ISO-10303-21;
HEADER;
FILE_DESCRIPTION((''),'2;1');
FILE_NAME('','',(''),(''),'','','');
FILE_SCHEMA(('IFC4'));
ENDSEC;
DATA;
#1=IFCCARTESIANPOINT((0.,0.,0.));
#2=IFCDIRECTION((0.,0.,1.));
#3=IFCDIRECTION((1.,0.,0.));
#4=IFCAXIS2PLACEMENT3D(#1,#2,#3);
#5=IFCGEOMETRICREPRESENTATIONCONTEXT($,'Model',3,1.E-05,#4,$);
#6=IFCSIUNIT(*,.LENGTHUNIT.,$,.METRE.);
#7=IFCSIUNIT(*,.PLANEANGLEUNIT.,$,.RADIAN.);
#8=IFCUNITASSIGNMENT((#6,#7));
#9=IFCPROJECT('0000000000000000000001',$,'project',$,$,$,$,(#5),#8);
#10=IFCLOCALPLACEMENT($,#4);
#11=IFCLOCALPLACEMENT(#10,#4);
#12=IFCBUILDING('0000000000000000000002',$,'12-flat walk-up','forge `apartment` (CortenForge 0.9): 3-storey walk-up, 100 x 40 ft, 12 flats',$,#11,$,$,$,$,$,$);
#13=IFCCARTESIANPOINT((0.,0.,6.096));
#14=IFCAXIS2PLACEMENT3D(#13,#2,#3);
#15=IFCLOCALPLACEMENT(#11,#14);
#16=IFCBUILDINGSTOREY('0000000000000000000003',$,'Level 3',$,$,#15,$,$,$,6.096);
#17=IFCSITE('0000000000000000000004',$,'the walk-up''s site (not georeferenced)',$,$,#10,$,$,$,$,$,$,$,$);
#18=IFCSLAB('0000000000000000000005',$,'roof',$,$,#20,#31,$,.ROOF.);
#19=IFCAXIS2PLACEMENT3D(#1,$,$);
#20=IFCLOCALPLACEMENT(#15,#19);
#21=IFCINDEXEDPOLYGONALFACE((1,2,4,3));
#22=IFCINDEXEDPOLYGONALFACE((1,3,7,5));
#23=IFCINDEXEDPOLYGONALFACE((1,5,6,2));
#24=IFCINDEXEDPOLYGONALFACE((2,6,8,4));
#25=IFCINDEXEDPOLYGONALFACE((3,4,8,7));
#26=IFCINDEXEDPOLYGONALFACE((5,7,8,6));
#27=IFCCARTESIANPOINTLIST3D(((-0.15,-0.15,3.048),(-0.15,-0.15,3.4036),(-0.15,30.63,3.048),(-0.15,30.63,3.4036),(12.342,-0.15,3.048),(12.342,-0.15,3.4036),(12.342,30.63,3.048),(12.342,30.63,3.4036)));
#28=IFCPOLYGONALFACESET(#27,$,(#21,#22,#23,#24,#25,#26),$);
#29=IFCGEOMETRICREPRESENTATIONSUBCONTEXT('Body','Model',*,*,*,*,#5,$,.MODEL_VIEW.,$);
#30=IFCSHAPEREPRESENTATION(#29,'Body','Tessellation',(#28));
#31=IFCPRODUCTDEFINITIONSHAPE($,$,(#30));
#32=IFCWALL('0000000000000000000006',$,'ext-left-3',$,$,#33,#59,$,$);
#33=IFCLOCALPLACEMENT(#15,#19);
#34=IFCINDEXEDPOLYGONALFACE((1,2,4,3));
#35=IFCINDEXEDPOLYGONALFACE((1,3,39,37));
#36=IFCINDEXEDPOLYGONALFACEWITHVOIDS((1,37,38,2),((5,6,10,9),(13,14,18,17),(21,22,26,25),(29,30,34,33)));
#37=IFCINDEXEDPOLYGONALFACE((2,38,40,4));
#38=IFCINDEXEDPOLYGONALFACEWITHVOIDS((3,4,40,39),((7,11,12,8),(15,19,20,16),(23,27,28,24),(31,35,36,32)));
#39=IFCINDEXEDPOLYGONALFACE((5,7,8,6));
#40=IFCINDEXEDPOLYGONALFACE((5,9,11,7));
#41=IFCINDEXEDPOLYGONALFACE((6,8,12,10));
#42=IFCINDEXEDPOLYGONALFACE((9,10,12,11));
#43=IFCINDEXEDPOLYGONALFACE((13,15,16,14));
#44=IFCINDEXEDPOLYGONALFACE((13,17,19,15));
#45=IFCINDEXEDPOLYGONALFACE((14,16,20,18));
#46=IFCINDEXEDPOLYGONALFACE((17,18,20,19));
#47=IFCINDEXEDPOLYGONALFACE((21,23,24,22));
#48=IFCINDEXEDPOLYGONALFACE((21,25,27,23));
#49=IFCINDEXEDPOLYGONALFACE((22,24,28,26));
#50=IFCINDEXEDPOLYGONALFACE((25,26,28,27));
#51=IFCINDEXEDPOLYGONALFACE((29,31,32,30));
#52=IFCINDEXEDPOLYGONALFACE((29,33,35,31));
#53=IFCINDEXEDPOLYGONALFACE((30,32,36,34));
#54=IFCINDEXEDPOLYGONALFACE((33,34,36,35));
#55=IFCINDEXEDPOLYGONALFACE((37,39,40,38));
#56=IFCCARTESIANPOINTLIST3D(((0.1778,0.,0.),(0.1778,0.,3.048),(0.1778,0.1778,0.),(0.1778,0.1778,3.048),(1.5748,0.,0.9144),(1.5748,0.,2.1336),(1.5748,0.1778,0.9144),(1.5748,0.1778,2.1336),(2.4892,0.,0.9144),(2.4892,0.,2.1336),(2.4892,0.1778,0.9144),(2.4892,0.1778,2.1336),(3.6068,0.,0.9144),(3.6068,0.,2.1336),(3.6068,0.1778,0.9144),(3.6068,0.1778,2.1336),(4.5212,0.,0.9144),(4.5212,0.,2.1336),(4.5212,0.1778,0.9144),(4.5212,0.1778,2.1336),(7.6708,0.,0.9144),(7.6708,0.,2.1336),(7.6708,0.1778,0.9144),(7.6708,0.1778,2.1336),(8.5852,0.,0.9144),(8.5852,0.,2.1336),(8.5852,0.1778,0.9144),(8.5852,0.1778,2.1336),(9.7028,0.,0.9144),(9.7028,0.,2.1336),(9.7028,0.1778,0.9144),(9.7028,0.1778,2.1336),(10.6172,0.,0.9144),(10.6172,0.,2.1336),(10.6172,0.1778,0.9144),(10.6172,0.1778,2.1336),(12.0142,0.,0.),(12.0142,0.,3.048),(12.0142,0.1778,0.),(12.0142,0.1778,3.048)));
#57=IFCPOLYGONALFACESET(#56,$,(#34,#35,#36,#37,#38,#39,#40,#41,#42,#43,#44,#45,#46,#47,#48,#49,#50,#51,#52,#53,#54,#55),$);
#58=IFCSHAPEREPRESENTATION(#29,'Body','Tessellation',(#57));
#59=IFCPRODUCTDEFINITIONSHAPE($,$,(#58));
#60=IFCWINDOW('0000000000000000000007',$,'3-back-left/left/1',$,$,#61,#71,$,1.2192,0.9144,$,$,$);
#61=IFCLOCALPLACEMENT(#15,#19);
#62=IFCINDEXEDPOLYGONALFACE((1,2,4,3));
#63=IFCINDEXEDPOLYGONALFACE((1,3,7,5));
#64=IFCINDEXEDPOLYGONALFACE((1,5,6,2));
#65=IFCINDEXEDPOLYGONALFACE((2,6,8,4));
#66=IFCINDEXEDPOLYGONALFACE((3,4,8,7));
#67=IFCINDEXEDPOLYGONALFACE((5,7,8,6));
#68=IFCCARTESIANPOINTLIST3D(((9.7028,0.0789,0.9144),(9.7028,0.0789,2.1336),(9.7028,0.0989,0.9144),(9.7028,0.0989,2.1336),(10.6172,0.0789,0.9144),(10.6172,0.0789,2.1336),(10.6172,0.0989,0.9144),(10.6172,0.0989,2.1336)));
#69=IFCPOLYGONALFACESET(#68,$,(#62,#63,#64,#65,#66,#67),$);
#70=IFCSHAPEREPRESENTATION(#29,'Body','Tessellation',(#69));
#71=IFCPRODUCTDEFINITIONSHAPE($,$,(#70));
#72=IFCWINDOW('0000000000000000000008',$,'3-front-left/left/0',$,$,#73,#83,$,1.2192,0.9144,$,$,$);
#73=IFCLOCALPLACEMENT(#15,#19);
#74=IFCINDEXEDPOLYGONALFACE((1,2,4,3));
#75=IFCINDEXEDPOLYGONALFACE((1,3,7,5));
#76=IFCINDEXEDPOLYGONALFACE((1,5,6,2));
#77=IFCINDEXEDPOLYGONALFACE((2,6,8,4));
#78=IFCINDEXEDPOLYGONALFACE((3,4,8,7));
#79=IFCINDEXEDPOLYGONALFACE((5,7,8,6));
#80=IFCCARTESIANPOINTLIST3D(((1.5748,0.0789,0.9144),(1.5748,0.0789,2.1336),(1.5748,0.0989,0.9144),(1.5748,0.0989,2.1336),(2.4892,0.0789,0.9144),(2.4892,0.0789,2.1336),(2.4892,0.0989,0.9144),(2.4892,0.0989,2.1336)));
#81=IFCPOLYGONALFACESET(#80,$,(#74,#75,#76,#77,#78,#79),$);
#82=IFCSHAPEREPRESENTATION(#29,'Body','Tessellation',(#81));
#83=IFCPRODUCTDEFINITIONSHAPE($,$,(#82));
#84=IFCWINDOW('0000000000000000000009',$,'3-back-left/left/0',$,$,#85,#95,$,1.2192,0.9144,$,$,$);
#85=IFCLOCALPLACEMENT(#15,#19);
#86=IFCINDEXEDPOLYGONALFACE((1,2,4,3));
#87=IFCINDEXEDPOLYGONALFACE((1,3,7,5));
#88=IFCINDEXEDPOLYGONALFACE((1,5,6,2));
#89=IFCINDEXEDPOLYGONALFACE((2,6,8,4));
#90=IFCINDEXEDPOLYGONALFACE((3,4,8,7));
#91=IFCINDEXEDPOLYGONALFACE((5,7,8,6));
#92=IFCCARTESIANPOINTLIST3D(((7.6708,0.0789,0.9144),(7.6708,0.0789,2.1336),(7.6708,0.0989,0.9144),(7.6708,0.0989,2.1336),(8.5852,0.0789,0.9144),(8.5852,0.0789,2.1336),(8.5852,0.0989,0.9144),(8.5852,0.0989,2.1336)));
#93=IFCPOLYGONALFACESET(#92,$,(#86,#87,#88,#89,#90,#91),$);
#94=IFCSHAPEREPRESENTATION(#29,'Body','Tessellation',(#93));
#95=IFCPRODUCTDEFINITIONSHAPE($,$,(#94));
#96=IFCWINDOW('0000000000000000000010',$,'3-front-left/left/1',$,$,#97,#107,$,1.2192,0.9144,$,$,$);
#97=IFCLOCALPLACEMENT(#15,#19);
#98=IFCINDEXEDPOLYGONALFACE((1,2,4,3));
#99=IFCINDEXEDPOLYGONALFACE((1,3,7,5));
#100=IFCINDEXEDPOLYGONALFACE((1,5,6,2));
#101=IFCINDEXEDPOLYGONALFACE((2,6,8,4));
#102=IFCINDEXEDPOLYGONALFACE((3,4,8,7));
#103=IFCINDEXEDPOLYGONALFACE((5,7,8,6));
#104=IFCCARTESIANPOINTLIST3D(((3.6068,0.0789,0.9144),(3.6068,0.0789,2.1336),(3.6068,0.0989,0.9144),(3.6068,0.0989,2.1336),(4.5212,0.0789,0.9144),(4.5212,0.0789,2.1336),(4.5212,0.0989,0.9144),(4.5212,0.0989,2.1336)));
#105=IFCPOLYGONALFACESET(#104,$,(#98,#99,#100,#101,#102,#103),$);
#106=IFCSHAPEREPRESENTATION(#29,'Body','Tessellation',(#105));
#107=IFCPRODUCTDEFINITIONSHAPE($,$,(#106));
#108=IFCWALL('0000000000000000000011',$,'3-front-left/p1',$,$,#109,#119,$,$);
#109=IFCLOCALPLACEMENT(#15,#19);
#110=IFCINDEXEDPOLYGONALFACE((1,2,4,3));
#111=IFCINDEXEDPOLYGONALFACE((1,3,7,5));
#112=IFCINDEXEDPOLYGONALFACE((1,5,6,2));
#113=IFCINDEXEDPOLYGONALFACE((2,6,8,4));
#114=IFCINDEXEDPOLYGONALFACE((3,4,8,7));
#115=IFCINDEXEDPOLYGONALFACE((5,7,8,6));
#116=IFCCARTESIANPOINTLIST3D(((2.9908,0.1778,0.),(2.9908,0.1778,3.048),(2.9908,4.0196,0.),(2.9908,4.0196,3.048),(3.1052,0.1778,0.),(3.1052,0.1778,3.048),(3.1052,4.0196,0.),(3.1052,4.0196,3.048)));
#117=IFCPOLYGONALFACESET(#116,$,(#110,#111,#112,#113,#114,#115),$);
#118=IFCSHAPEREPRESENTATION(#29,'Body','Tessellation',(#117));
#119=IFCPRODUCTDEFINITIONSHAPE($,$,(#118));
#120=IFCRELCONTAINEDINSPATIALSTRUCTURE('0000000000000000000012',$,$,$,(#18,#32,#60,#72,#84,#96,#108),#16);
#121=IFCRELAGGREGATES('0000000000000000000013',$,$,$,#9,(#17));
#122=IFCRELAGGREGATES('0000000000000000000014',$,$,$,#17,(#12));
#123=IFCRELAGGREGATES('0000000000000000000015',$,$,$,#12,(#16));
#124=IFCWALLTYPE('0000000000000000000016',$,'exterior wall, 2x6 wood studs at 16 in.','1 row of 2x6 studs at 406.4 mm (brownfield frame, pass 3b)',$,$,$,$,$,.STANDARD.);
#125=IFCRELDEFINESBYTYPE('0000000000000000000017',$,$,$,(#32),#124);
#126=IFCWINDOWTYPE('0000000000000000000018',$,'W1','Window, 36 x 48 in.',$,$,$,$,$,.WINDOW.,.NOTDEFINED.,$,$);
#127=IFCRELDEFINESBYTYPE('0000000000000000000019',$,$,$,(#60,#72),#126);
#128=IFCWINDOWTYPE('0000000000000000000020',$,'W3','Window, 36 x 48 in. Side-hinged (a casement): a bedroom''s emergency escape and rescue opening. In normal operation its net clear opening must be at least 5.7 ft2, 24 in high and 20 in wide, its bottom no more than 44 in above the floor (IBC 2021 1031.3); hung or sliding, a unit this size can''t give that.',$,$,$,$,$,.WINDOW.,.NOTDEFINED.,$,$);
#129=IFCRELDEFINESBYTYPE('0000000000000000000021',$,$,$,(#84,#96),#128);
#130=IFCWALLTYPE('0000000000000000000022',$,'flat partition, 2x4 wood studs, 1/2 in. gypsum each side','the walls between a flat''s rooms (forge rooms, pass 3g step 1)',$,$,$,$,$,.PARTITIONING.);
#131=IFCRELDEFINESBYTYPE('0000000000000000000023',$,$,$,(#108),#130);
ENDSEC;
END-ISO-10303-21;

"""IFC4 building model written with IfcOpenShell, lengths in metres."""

from ifc_helpers import new_model, si_unit, frame, frame_2d, origin, origin_with_axes, place, context, subcontext, project, spatial, rectangle, extrude, type_object, element, fill, save


model = new_model("IFC4")

# Units and contexts
model_context = context("Model", 3, precision=1e-05, world=origin_with_axes())
body_context = subcontext(model_context, "Body", "Model", "MODEL_VIEW")
ifc_project = project(units=[si_unit("LENGTHUNIT", "METRE"), si_unit("PLANEANGLEUNIT", "RADIAN")], contexts=[model_context])

# Site, building, storey
site_placement = place(None, origin_with_axes())
site = spatial("IfcSite", under=ifc_project, at=site_placement, Name="the walk-up's site (not georeferenced)")
building_placement = place(site_placement, origin_with_axes())
building = spatial("IfcBuilding", under=site, at=building_placement, Name="12-flat walk-up", Description="forge `apartment` (CortenForge 0.9): 3-storey walk-up, 100 x 40 ft, 12 flats")
storey_placement = place(building_placement, frame((0.0, 0.0, 6.096), z_axis=(0.0, 0.0, 1.0), x_axis=(1.0, 0.0, 0.0)))
storey = spatial("IfcBuildingStorey", under=building, at=storey_placement, Name="Level 3", Elevation=6.096)

# Slab
slab_placement = place(storey_placement, frame((-0.15, -0.15, 3.048), z_axis=(0.0, 0.0, 1.0), x_axis=(1.0, 0.0, 0.0)))
element("IfcSlab", 1, at=slab_placement, inside=storey, Name="roof", PredefinedType="ROOF", context=body_context, shape_type="SweptSolid", body=[
    extrude(rectangle(XDim=12.492, YDim=30.78, at=frame_2d((6.246, 15.39))), origin(), (0.0, 0.0, 1.0), 0.3556),
])

# Wall, openings, windows
wall_type_1 = type_object("IfcWallType", Name="exterior wall, 2x6 wood studs at 16 in.", Description="1 row of 2x6 studs at 406.4 mm (brownfield frame, pass 3b)", PredefinedType="STANDARD")
wall_1_placement = place(storey_placement, frame((0.1778, 0.0, 0.0), z_axis=(0.0, 0.0, 1.0), x_axis=(1.0, 0.0, 0.0)))
wall_1 = element("IfcWall", 2, at=wall_1_placement, inside=storey, type_object=wall_type_1, Name="ext-left-3", context=body_context, shape_type="SweptSolid", body=[
    extrude(rectangle(XDim=11.8364, YDim=0.1778, at=frame_2d((5.9182, 0.0889))), origin(), (0.0, 0.0, 1.0), 3.048),
])
opening_1_placement = place(wall_1_placement, frame((7.493, 0.0, 0.9144), z_axis=(0.0, 0.0, 1.0), x_axis=(1.0, 0.0, 0.0)))
opening_1 = element("IfcOpeningElement", 3, at=opening_1_placement, cuts=wall_1, PredefinedType="OPENING", context=body_context, shape_type="SweptSolid", body=[
    extrude(rectangle(XDim=0.9144, YDim=0.1778, at=frame_2d((0.4572, 0.0889))), origin(), (0.0, 0.0, 1.0), 1.2192),
])
opening_2_placement = place(wall_1_placement, frame((9.525, 0.0, 0.9144), z_axis=(0.0, 0.0, 1.0), x_axis=(1.0, 0.0, 0.0)))
opening_2 = element("IfcOpeningElement", 4, at=opening_2_placement, cuts=wall_1, PredefinedType="OPENING", context=body_context, shape_type="SweptSolid", body=[
    extrude(rectangle(XDim=0.9144, YDim=0.1778, at=frame_2d((0.4572, 0.0889))), origin(), (0.0, 0.0, 1.0), 1.2192),
])
opening_3_placement = place(wall_1_placement, frame((1.397, 0.0, 0.9144), z_axis=(0.0, 0.0, 1.0), x_axis=(1.0, 0.0, 0.0)))
opening_3 = element("IfcOpeningElement", 5, at=opening_3_placement, cuts=wall_1, PredefinedType="OPENING", context=body_context, shape_type="SweptSolid", body=[
    extrude(rectangle(XDim=0.9144, YDim=0.1778, at=frame_2d((0.4572, 0.0889))), origin(), (0.0, 0.0, 1.0), 1.2192),
])
opening_4_placement = place(wall_1_placement, frame((3.429, 0.0, 0.9144), z_axis=(0.0, 0.0, 1.0), x_axis=(1.0, 0.0, 0.0)))
opening_4 = element("IfcOpeningElement", 6, at=opening_4_placement, cuts=wall_1, PredefinedType="OPENING", context=body_context, shape_type="SweptSolid", body=[
    extrude(rectangle(XDim=0.9144, YDim=0.1778, at=frame_2d((0.4572, 0.0889))), origin(), (0.0, 0.0, 1.0), 1.2192),
])
window_type_1 = type_object("IfcWindowType", Name="W1", Description="Window, 36 x 48 in.", PartitioningType="NOTDEFINED", PredefinedType="WINDOW")
window_1_placement = place(opening_2_placement, frame((0.0, 0.0789, 0.0), z_axis=(0.0, 0.0, 1.0), x_axis=(1.0, 0.0, 0.0)))
window_1 = element("IfcWindow", 7, at=window_1_placement, inside=storey, type_object=window_type_1, Name="3-back-left/left/1", OverallHeight=1.2192, OverallWidth=0.9144, context=body_context, shape_type="SweptSolid", body=[
    extrude(rectangle(XDim=0.9144, YDim=0.02, at=frame_2d((0.4572, 0.01))), origin(), (0.0, 0.0, 1.0), 1.2192),
])
fill(opening_2, window_1)
window_2_placement = place(opening_3_placement, frame((0.0, 0.0789, 0.0), z_axis=(0.0, 0.0, 1.0), x_axis=(1.0, 0.0, 0.0)))
window_2 = element("IfcWindow", 8, at=window_2_placement, inside=storey, type_object=window_type_1, Name="3-front-left/left/0", OverallHeight=1.2192, OverallWidth=0.9144, context=body_context, shape_type="SweptSolid", body=[
    extrude(rectangle(XDim=0.9144, YDim=0.02, at=frame_2d((0.4572, 0.01))), origin(), (0.0, 0.0, 1.0), 1.2192),
])
fill(opening_3, window_2)
window_type_2 = type_object("IfcWindowType", Name="W3", Description="Window, 36 x 48 in. Side-hinged (a casement): a bedroom's emergency escape and rescue opening. In normal operation its net clear opening must be at least 5.7 ft2, 24 in high and 20 in wide, its bottom no more than 44 in above the floor (IBC 2021 1031.3); hung or sliding, a unit this size can't give that.", PartitioningType="NOTDEFINED", PredefinedType="WINDOW")
window_3_placement = place(opening_1_placement, frame((0.0, 0.0789, 0.0), z_axis=(0.0, 0.0, 1.0), x_axis=(1.0, 0.0, 0.0)))
window_3 = element("IfcWindow", 9, at=window_3_placement, inside=storey, type_object=window_type_2, Name="3-back-left/left/0", OverallHeight=1.2192, OverallWidth=0.9144, context=body_context, shape_type="SweptSolid", body=[
    extrude(rectangle(XDim=0.9144, YDim=0.02, at=frame_2d((0.4572, 0.01))), origin(), (0.0, 0.0, 1.0), 1.2192),
])
fill(opening_1, window_3)
window_4_placement = place(opening_4_placement, frame((0.0, 0.0789, 0.0), z_axis=(0.0, 0.0, 1.0), x_axis=(1.0, 0.0, 0.0)))
window_4 = element("IfcWindow", 10, at=window_4_placement, inside=storey, type_object=window_type_2, Name="3-front-left/left/1", OverallHeight=1.2192, OverallWidth=0.9144, context=body_context, shape_type="SweptSolid", body=[
    extrude(rectangle(XDim=0.9144, YDim=0.02, at=frame_2d((0.4572, 0.01))), origin(), (0.0, 0.0, 1.0), 1.2192),
])
fill(opening_4, window_4)

# Wall
wall_type_2 = type_object("IfcWallType", Name="flat partition, 2x4 wood studs, 1/2 in. gypsum each side", Description="the walls between a flat's rooms (forge rooms, pass 3g step 1)", PredefinedType="PARTITIONING")
wall_2_placement = place(storey_placement, frame((2.9909, 0.1778, 0.0), z_axis=(0.0, 0.0, 1.0), x_axis=(1.0, 0.0, 0.0)))
element("IfcWall", 11, at=wall_2_placement, inside=storey, type_object=wall_type_2, Name="3-front-left/p1", context=body_context, shape_type="SweptSolid", body=[
    extrude(rectangle(XDim=0.1143, YDim=3.8417, at=frame_2d((0.0572, 1.9209))), origin(), (0.0, 0.0, 1.0), 3.048),
])

save(model, "model.ifc")
